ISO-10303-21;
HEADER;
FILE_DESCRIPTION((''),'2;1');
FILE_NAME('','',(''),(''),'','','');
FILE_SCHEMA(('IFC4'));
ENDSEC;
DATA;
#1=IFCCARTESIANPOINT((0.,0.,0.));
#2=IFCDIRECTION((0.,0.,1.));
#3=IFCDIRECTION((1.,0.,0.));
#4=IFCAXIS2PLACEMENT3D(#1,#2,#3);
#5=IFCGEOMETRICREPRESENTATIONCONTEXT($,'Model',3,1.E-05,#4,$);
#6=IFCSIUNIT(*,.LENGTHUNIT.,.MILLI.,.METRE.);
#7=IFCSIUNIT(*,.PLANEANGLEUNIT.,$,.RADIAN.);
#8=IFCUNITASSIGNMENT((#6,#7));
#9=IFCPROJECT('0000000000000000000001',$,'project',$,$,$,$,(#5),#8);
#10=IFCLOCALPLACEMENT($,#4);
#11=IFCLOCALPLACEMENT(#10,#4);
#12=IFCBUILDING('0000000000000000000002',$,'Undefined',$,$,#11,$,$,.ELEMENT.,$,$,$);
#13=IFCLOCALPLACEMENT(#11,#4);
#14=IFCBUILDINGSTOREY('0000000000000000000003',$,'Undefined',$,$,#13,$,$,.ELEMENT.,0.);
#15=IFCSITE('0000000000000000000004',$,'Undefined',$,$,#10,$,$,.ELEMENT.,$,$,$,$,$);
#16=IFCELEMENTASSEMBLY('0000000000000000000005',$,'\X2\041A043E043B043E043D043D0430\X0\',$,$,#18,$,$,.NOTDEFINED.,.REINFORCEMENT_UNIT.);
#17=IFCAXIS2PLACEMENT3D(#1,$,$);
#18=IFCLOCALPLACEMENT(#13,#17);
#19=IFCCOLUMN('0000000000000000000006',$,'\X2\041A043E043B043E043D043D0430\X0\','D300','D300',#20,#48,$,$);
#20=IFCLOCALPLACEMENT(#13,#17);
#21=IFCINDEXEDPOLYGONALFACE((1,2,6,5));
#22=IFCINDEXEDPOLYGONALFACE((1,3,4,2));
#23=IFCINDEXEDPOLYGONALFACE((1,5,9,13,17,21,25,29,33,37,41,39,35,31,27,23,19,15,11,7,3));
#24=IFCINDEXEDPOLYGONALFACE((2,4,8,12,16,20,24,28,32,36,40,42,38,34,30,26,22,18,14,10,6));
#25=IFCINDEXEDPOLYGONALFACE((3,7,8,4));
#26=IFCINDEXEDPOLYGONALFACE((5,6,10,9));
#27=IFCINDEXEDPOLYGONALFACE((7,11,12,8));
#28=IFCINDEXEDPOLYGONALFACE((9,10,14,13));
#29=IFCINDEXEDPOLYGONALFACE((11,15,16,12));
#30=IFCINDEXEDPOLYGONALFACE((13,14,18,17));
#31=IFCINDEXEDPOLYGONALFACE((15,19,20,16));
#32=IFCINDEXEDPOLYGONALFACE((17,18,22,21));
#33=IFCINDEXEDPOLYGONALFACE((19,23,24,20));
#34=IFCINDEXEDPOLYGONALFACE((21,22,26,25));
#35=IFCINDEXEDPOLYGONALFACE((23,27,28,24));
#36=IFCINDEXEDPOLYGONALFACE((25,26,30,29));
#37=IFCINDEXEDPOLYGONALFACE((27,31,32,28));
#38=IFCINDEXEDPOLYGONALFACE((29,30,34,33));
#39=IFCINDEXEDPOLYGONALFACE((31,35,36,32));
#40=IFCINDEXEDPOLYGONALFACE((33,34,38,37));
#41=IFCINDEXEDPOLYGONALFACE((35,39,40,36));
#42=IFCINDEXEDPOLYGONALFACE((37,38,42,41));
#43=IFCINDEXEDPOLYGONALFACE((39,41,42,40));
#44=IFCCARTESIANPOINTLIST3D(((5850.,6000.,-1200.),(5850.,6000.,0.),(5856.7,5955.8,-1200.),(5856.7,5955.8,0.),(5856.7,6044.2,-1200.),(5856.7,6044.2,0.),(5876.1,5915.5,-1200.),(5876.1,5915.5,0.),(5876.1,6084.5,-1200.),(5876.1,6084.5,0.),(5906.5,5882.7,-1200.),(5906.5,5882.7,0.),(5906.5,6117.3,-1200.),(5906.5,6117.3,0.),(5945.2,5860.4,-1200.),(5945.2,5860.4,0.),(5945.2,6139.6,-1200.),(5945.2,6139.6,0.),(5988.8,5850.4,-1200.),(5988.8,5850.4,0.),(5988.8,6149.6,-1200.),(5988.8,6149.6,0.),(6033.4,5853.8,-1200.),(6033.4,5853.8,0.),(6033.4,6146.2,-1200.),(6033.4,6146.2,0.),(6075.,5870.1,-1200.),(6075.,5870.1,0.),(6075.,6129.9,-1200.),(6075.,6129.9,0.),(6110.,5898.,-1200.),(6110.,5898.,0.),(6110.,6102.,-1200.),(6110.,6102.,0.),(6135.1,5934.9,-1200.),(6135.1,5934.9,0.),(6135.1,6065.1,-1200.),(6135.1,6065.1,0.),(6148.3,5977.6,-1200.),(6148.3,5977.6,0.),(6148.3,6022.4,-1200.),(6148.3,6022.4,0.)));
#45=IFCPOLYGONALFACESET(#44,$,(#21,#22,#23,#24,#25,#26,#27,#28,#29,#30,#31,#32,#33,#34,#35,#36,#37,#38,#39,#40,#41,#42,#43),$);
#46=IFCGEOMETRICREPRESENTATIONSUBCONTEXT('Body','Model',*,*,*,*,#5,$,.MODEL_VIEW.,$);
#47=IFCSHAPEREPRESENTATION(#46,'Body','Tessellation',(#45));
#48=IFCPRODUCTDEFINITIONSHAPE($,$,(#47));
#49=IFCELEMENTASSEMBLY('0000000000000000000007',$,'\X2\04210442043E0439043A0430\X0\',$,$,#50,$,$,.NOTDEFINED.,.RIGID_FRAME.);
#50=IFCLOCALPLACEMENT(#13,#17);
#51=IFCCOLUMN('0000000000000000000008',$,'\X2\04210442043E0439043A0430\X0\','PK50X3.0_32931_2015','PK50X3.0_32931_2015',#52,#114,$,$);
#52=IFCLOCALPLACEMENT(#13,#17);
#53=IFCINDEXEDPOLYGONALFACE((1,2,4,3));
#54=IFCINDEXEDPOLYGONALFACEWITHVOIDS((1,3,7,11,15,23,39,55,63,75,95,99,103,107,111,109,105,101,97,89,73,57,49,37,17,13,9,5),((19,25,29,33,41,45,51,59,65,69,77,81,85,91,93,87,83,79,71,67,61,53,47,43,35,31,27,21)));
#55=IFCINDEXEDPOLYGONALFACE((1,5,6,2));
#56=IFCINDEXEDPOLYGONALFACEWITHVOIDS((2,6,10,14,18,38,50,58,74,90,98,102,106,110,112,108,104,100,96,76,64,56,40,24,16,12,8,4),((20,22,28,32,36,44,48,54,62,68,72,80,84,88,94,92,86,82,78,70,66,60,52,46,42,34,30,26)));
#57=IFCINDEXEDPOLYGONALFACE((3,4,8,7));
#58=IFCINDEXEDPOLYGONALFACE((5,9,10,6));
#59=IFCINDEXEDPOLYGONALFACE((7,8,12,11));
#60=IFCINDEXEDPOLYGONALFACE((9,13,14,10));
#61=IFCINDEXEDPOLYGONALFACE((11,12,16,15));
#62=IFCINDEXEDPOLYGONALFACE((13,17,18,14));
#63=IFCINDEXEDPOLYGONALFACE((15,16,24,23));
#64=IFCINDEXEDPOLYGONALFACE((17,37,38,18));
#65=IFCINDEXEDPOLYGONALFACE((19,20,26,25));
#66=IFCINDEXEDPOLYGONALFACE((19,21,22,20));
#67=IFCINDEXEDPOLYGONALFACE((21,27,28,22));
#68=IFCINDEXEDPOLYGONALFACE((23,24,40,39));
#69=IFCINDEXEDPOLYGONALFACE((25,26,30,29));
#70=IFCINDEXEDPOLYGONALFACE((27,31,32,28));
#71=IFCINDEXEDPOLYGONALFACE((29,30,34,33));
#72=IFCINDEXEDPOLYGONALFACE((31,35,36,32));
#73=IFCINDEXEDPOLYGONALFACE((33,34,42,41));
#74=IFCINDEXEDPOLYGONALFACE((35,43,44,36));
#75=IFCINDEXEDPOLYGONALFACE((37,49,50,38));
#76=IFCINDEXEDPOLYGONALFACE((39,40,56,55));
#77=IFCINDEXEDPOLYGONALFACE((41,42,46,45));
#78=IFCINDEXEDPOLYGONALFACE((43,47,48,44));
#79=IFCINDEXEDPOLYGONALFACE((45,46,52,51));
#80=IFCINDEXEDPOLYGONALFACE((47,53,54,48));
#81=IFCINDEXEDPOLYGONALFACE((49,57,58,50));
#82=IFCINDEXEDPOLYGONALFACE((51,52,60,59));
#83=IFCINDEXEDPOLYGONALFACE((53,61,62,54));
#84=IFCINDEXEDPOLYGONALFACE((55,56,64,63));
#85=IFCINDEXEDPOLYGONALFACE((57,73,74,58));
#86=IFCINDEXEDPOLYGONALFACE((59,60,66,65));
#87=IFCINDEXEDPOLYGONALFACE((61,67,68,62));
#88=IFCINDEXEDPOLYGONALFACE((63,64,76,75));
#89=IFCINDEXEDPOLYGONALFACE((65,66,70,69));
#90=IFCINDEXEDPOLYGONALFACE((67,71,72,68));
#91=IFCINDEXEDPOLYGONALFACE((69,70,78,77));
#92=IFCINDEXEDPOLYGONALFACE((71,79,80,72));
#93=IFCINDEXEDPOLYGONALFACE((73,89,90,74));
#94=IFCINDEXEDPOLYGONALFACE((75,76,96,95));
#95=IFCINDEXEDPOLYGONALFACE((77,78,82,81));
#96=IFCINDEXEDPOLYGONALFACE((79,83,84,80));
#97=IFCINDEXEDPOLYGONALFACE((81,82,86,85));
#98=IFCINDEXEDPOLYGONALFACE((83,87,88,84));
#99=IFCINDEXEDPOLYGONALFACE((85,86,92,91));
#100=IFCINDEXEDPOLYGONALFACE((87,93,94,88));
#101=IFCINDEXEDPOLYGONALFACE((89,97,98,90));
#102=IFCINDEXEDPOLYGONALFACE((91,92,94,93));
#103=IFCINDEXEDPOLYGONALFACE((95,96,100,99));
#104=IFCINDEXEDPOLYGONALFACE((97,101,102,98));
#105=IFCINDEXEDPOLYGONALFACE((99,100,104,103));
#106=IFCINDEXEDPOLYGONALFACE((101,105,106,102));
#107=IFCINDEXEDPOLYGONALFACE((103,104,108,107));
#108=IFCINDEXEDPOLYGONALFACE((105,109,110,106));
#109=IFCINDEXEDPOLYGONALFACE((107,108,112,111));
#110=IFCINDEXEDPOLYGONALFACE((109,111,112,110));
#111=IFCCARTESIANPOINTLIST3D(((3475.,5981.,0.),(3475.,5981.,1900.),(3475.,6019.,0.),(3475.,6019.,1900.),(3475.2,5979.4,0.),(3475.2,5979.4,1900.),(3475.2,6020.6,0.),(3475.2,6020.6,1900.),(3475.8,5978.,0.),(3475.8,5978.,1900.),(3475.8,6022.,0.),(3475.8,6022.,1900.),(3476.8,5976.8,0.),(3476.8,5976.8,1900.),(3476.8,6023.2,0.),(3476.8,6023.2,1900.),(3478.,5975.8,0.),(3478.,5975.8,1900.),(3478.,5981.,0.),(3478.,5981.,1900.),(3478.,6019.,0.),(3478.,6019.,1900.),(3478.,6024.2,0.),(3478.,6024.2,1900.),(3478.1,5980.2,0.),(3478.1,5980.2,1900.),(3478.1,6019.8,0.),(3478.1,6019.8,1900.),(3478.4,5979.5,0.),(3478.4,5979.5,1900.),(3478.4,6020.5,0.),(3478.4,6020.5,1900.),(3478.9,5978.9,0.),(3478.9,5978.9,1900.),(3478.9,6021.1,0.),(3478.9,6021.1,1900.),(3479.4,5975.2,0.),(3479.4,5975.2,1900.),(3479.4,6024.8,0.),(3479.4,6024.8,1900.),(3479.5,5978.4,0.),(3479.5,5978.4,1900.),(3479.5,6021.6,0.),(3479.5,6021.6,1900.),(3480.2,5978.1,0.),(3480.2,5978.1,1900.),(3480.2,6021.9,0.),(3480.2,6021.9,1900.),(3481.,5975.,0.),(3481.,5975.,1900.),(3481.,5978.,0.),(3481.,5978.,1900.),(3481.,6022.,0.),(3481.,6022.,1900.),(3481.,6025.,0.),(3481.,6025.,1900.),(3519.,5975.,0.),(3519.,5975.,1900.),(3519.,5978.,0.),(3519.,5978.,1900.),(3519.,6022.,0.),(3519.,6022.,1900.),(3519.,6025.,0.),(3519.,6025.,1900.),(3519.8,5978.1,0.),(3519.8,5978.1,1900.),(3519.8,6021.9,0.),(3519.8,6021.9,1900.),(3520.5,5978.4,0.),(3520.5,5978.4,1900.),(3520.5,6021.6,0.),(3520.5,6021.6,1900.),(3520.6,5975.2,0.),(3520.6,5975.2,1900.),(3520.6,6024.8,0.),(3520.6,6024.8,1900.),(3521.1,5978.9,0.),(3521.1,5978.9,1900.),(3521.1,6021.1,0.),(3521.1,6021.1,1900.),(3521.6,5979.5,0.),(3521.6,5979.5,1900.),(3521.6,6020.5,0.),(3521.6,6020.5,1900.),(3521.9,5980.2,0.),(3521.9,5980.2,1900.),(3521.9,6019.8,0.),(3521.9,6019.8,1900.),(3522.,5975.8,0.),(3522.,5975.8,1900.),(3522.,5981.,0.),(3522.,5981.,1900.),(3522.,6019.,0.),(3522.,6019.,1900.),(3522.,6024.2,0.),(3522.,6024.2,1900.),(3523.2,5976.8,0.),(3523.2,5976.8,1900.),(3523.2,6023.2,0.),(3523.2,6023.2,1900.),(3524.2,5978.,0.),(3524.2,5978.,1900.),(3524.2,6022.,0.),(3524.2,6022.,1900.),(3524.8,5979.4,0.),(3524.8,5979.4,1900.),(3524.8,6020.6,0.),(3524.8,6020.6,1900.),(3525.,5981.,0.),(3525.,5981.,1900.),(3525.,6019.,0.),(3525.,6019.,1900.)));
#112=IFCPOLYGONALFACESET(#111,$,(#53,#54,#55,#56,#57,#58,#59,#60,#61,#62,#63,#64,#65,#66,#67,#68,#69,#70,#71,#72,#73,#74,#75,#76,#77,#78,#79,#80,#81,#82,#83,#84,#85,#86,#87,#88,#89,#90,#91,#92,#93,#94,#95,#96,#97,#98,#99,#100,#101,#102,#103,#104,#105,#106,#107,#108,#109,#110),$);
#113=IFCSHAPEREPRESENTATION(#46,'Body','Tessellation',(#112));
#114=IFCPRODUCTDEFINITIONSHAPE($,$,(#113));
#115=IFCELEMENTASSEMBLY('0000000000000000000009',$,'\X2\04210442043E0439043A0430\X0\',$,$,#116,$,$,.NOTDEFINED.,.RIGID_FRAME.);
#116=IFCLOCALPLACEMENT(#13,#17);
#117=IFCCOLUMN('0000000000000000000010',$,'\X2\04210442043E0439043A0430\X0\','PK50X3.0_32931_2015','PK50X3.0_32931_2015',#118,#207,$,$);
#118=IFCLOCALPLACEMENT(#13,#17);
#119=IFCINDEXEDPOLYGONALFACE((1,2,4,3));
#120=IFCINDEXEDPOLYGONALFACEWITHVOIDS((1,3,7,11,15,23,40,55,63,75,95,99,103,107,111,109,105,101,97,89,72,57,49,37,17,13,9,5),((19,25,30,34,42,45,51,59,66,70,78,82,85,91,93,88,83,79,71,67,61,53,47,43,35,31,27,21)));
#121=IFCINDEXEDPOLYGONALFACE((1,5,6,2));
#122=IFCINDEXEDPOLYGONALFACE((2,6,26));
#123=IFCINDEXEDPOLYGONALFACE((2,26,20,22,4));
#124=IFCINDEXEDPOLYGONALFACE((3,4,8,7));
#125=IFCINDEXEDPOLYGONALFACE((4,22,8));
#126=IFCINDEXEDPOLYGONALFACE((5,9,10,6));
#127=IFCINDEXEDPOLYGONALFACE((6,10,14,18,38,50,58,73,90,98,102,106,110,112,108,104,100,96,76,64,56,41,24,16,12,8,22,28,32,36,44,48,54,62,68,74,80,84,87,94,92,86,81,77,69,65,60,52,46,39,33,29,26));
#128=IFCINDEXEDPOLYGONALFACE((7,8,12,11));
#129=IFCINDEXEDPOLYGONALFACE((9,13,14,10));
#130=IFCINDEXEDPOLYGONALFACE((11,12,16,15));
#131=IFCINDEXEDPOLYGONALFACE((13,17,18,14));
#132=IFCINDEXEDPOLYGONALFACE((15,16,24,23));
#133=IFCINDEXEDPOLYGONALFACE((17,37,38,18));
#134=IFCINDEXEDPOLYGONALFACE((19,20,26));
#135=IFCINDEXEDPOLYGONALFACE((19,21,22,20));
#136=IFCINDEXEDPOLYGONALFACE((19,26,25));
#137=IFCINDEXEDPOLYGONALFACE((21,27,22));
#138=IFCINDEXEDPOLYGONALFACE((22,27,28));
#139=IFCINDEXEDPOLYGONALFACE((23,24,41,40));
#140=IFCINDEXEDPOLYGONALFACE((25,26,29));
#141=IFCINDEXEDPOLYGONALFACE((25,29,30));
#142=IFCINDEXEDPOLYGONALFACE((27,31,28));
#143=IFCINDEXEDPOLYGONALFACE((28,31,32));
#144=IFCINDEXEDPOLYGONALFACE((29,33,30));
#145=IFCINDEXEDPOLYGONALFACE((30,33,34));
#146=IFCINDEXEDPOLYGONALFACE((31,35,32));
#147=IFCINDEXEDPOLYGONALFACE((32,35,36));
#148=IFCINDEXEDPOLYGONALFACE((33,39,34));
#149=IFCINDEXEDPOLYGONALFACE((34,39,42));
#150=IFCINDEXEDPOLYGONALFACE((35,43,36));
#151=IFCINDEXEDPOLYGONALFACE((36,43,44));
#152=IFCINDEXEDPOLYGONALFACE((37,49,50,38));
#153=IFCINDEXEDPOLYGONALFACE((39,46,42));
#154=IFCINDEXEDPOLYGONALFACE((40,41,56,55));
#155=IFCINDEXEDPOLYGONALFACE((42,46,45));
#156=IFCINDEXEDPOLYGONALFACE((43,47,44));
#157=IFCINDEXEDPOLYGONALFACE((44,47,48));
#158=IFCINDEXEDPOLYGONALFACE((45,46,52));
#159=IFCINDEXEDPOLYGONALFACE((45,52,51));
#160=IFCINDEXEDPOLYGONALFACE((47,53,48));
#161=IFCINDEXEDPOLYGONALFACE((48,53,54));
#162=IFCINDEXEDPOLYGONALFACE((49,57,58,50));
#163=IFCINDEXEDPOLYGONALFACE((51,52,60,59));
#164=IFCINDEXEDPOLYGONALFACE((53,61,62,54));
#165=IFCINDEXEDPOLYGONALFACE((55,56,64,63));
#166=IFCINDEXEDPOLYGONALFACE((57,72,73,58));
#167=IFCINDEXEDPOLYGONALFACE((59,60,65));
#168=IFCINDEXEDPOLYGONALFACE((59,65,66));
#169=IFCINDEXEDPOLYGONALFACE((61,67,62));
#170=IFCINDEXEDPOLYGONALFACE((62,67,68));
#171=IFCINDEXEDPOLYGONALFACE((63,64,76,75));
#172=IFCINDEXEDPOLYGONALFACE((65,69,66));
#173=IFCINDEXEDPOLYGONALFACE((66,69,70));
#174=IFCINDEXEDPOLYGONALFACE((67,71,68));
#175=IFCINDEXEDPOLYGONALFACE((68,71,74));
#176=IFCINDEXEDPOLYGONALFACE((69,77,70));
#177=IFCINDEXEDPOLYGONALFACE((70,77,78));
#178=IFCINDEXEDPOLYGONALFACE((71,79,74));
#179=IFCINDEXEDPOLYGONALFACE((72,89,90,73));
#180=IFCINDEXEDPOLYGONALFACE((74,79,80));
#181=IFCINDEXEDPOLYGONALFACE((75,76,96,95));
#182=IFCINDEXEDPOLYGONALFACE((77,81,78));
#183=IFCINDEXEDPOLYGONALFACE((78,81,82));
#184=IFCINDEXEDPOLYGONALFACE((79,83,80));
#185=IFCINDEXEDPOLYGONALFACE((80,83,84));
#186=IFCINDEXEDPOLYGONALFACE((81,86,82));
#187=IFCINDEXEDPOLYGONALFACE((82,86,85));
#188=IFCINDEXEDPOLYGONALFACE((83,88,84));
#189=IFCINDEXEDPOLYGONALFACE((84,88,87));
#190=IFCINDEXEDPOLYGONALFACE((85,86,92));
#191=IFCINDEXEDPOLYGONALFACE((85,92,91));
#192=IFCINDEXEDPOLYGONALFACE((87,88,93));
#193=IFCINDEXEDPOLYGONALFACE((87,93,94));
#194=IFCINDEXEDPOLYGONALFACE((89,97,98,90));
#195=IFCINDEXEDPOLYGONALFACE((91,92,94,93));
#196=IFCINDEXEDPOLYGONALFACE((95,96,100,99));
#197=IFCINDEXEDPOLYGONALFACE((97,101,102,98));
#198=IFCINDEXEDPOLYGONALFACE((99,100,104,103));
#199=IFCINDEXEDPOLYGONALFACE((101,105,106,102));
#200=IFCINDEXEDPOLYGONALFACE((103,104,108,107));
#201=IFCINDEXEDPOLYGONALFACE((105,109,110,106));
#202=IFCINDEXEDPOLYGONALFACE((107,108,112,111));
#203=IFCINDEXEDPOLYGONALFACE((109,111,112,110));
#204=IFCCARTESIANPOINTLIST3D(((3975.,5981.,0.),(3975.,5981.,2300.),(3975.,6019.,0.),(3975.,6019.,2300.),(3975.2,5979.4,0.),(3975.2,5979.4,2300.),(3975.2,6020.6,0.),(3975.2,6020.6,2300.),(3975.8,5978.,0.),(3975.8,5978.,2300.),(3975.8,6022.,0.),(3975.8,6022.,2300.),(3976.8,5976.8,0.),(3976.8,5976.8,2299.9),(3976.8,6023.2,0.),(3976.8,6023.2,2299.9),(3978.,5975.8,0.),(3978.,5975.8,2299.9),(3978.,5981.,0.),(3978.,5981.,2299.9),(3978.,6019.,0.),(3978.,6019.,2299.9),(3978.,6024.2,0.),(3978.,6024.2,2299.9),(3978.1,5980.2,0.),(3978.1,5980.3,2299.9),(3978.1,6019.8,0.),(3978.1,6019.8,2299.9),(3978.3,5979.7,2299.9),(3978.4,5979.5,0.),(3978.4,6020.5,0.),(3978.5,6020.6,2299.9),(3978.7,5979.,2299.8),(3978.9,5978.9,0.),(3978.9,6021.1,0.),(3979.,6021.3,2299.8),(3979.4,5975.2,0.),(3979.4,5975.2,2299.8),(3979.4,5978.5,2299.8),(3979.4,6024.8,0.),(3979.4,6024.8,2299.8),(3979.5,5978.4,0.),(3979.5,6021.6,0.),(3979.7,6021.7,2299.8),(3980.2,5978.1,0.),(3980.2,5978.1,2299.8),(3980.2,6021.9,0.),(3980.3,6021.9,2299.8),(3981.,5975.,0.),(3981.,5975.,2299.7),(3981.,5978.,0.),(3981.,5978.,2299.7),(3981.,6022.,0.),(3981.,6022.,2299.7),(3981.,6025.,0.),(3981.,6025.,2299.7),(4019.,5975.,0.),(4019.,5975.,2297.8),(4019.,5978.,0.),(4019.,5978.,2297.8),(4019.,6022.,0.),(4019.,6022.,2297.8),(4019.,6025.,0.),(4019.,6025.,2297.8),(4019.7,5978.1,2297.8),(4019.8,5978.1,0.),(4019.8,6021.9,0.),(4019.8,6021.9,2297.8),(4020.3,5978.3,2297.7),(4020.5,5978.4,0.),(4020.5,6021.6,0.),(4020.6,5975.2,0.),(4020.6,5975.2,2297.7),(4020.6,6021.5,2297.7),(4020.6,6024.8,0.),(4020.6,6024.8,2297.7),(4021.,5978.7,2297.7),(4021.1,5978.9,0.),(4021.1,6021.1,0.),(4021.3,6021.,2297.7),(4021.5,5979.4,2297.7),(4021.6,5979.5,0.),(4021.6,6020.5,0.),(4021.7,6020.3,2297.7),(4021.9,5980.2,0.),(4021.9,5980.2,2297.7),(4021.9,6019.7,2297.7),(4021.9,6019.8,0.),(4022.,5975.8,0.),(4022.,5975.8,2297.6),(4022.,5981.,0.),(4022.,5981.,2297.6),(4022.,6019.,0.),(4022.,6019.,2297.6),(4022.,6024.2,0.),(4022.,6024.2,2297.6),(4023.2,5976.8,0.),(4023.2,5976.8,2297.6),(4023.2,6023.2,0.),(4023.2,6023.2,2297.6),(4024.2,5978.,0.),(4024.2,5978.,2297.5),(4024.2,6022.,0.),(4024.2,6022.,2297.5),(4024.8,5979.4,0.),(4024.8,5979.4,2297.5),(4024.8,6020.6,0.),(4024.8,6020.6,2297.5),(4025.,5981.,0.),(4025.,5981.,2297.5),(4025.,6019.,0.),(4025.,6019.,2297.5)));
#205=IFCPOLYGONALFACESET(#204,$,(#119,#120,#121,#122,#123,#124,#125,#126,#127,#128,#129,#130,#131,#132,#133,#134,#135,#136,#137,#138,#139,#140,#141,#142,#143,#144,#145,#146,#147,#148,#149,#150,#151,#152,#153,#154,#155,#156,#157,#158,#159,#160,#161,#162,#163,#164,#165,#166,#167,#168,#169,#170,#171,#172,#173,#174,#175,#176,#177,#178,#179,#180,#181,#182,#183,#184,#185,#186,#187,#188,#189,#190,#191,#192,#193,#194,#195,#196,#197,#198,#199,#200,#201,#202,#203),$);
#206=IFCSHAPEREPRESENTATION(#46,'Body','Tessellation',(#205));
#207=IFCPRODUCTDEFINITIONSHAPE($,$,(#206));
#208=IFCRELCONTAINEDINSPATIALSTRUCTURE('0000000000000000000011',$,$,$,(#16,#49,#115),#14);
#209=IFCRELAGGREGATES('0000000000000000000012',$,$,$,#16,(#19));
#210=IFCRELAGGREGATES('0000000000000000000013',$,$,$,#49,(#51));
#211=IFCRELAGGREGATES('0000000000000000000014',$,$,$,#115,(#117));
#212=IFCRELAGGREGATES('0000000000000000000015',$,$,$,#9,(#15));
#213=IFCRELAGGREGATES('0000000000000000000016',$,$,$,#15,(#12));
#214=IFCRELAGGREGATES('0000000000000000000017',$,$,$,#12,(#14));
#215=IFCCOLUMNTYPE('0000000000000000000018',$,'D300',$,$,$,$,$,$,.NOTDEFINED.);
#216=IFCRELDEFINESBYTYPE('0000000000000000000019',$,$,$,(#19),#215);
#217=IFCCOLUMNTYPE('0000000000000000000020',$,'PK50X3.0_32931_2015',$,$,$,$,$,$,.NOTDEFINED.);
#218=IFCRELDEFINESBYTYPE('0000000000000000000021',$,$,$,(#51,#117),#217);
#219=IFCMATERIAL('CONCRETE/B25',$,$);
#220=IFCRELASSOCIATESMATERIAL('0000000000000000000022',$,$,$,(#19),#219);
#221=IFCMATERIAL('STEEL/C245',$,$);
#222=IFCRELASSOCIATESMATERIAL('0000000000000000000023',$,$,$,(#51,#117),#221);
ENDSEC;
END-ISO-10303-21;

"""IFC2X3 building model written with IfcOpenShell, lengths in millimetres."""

from ifc_helpers import new_model, si_unit, frame, origin_with_axes, origin_2d_with_axis, place, context, subcontext, project, spatial, hollow_rectangle, circle, extrude, clip, halfspace, material, type_object, element, aggregate, save


model = new_model("IFC2X3")

# Units and contexts
model_context = context("Model", 3, precision=1e-05, world=origin_with_axes())
body_context = subcontext(model_context, "Body", "Model", "MODEL_VIEW")
ifc_project = project(units=[si_unit("LENGTHUNIT", "METRE", prefix="MILLI"), si_unit("PLANEANGLEUNIT", "RADIAN")], contexts=[model_context])

# Site, building, storey
site_placement = place(None, origin_with_axes())
site = spatial("IfcSite", under=ifc_project, at=site_placement, Name="Undefined", CompositionType="ELEMENT")
building_placement = place(site_placement, origin_with_axes())
building = spatial("IfcBuilding", under=site, at=building_placement, Name="Undefined", CompositionType="ELEMENT")
storey_placement = place(building_placement, origin_with_axes())
storey = spatial("IfcBuildingStorey", under=building, at=storey_placement, Name="Undefined", CompositionType="ELEMENT", Elevation=0.0)

# Element assemblies, columns
assembly_1_placement = place(storey_placement, origin_with_axes())
assembly_1 = element("IfcElementAssembly", 1, at=assembly_1_placement, inside=storey, Name="Колонна", AssemblyPlace="NOTDEFINED", PredefinedType="REINFORCEMENT_UNIT")
ifc_material_1 = material(Name="CONCRETE/B25")
column_type_1 = type_object("IfcColumnType", Name="D300", PredefinedType="NOTDEFINED")
column_1_placement = place(assembly_1_placement, frame((6000.0, 6000.0, -1200.0), z_axis=(0.0, 0.0, 1.0), x_axis=(0.0, 1.0, 0.0)))
column_1 = element("IfcColumn", 2, at=column_1_placement, type_object=column_type_1, material=ifc_material_1, Name="Колонна", Description="D300", ObjectType="D300", context=body_context, shape_type="SweptSolid", body=[
    extrude(circle(Radius=150.0, at=origin_2d_with_axis()), frame((0.0, 0.0, 1200.0), z_axis=(0.0, 0.0, -1.0), x_axis=(0.0, 1.0, 0.0)), (0.0, 0.0, 1.0), 1200.0),
])
aggregate(assembly_1, [column_1])
assembly_2_placement = place(storey_placement, origin_with_axes())
assembly_2 = element("IfcElementAssembly", 3, at=assembly_2_placement, inside=storey, Name="Стойка", AssemblyPlace="NOTDEFINED", PredefinedType="RIGID_FRAME")
ifc_material_2 = material(Name="STEEL/C245")
column_type_2 = type_object("IfcColumnType", Name="PK50X3.0_32931_2015", PredefinedType="NOTDEFINED")
column_2_placement = place(assembly_2_placement, frame((3500.0, 6000.0, 0.0), z_axis=(0.0, 0.0, 1.0), x_axis=(0.0, 1.0, 0.0)))
column_2 = element("IfcColumn", 4, at=column_2_placement, type_object=column_type_2, material=ifc_material_2, Name="Стойка", Description="PK50X3.0_32931_2015", ObjectType="PK50X3.0_32931_2015", context=body_context, shape_type="Clipping", body=[
    clip(extrude(hollow_rectangle(XDim=50.0, YDim=50.0, WallThickness=3.0, InnerFilletRadius=3.0, OuterFilletRadius=6.0, at=origin_2d_with_axis()), frame((0.0, 0.0, 1900.0), z_axis=(0.0, 0.0, -1.0), x_axis=(0.0, 1.0, 0.0)), (0.0, 0.0, 1.0), 1900.0), halfspace(frame((0.0, 864.8, 1900.0), z_axis=(0.0, 0.0, -1.0), x_axis=(-1.0, 0.0, 0.0)), True)),
])
aggregate(assembly_2, [column_2])
assembly_3_placement = place(storey_placement, origin_with_axes())
assembly_3 = element("IfcElementAssembly", 5, at=assembly_3_placement, inside=storey, Name="Стойка", AssemblyPlace="NOTDEFINED", PredefinedType="RIGID_FRAME")
column_3_placement = place(assembly_3_placement, frame((4000.0, 6000.0, 0.0), z_axis=(0.0, 0.0, 1.0), x_axis=(0.0, 1.0, 0.0)))
column_3 = element("IfcColumn", 6, at=column_3_placement, type_object=column_type_2, material=ifc_material_2, Name="Стойка", Description="PK50X3.0_32931_2015", ObjectType="PK50X3.0_32931_2015", context=body_context, shape_type="Clipping", body=[
    clip(extrude(hollow_rectangle(XDim=50.0, YDim=50.0, WallThickness=3.0, InnerFilletRadius=3.0, OuterFilletRadius=6.0, at=origin_2d_with_axis()), frame((0.0, 0.0, 2300.0), z_axis=(0.0, 0.0, -1.0), x_axis=(0.0, 1.0, 0.0)), (0.0, 0.0, 1.0), 2300.1), halfspace(frame((0.0, -147.1, 2291.3), z_axis=(0.0, 0.050782, -0.99871), x_axis=(-1.0, 0.0, 0.0)), True)),
])
aggregate(assembly_3, [column_3])

save(model, "model.ifc")
